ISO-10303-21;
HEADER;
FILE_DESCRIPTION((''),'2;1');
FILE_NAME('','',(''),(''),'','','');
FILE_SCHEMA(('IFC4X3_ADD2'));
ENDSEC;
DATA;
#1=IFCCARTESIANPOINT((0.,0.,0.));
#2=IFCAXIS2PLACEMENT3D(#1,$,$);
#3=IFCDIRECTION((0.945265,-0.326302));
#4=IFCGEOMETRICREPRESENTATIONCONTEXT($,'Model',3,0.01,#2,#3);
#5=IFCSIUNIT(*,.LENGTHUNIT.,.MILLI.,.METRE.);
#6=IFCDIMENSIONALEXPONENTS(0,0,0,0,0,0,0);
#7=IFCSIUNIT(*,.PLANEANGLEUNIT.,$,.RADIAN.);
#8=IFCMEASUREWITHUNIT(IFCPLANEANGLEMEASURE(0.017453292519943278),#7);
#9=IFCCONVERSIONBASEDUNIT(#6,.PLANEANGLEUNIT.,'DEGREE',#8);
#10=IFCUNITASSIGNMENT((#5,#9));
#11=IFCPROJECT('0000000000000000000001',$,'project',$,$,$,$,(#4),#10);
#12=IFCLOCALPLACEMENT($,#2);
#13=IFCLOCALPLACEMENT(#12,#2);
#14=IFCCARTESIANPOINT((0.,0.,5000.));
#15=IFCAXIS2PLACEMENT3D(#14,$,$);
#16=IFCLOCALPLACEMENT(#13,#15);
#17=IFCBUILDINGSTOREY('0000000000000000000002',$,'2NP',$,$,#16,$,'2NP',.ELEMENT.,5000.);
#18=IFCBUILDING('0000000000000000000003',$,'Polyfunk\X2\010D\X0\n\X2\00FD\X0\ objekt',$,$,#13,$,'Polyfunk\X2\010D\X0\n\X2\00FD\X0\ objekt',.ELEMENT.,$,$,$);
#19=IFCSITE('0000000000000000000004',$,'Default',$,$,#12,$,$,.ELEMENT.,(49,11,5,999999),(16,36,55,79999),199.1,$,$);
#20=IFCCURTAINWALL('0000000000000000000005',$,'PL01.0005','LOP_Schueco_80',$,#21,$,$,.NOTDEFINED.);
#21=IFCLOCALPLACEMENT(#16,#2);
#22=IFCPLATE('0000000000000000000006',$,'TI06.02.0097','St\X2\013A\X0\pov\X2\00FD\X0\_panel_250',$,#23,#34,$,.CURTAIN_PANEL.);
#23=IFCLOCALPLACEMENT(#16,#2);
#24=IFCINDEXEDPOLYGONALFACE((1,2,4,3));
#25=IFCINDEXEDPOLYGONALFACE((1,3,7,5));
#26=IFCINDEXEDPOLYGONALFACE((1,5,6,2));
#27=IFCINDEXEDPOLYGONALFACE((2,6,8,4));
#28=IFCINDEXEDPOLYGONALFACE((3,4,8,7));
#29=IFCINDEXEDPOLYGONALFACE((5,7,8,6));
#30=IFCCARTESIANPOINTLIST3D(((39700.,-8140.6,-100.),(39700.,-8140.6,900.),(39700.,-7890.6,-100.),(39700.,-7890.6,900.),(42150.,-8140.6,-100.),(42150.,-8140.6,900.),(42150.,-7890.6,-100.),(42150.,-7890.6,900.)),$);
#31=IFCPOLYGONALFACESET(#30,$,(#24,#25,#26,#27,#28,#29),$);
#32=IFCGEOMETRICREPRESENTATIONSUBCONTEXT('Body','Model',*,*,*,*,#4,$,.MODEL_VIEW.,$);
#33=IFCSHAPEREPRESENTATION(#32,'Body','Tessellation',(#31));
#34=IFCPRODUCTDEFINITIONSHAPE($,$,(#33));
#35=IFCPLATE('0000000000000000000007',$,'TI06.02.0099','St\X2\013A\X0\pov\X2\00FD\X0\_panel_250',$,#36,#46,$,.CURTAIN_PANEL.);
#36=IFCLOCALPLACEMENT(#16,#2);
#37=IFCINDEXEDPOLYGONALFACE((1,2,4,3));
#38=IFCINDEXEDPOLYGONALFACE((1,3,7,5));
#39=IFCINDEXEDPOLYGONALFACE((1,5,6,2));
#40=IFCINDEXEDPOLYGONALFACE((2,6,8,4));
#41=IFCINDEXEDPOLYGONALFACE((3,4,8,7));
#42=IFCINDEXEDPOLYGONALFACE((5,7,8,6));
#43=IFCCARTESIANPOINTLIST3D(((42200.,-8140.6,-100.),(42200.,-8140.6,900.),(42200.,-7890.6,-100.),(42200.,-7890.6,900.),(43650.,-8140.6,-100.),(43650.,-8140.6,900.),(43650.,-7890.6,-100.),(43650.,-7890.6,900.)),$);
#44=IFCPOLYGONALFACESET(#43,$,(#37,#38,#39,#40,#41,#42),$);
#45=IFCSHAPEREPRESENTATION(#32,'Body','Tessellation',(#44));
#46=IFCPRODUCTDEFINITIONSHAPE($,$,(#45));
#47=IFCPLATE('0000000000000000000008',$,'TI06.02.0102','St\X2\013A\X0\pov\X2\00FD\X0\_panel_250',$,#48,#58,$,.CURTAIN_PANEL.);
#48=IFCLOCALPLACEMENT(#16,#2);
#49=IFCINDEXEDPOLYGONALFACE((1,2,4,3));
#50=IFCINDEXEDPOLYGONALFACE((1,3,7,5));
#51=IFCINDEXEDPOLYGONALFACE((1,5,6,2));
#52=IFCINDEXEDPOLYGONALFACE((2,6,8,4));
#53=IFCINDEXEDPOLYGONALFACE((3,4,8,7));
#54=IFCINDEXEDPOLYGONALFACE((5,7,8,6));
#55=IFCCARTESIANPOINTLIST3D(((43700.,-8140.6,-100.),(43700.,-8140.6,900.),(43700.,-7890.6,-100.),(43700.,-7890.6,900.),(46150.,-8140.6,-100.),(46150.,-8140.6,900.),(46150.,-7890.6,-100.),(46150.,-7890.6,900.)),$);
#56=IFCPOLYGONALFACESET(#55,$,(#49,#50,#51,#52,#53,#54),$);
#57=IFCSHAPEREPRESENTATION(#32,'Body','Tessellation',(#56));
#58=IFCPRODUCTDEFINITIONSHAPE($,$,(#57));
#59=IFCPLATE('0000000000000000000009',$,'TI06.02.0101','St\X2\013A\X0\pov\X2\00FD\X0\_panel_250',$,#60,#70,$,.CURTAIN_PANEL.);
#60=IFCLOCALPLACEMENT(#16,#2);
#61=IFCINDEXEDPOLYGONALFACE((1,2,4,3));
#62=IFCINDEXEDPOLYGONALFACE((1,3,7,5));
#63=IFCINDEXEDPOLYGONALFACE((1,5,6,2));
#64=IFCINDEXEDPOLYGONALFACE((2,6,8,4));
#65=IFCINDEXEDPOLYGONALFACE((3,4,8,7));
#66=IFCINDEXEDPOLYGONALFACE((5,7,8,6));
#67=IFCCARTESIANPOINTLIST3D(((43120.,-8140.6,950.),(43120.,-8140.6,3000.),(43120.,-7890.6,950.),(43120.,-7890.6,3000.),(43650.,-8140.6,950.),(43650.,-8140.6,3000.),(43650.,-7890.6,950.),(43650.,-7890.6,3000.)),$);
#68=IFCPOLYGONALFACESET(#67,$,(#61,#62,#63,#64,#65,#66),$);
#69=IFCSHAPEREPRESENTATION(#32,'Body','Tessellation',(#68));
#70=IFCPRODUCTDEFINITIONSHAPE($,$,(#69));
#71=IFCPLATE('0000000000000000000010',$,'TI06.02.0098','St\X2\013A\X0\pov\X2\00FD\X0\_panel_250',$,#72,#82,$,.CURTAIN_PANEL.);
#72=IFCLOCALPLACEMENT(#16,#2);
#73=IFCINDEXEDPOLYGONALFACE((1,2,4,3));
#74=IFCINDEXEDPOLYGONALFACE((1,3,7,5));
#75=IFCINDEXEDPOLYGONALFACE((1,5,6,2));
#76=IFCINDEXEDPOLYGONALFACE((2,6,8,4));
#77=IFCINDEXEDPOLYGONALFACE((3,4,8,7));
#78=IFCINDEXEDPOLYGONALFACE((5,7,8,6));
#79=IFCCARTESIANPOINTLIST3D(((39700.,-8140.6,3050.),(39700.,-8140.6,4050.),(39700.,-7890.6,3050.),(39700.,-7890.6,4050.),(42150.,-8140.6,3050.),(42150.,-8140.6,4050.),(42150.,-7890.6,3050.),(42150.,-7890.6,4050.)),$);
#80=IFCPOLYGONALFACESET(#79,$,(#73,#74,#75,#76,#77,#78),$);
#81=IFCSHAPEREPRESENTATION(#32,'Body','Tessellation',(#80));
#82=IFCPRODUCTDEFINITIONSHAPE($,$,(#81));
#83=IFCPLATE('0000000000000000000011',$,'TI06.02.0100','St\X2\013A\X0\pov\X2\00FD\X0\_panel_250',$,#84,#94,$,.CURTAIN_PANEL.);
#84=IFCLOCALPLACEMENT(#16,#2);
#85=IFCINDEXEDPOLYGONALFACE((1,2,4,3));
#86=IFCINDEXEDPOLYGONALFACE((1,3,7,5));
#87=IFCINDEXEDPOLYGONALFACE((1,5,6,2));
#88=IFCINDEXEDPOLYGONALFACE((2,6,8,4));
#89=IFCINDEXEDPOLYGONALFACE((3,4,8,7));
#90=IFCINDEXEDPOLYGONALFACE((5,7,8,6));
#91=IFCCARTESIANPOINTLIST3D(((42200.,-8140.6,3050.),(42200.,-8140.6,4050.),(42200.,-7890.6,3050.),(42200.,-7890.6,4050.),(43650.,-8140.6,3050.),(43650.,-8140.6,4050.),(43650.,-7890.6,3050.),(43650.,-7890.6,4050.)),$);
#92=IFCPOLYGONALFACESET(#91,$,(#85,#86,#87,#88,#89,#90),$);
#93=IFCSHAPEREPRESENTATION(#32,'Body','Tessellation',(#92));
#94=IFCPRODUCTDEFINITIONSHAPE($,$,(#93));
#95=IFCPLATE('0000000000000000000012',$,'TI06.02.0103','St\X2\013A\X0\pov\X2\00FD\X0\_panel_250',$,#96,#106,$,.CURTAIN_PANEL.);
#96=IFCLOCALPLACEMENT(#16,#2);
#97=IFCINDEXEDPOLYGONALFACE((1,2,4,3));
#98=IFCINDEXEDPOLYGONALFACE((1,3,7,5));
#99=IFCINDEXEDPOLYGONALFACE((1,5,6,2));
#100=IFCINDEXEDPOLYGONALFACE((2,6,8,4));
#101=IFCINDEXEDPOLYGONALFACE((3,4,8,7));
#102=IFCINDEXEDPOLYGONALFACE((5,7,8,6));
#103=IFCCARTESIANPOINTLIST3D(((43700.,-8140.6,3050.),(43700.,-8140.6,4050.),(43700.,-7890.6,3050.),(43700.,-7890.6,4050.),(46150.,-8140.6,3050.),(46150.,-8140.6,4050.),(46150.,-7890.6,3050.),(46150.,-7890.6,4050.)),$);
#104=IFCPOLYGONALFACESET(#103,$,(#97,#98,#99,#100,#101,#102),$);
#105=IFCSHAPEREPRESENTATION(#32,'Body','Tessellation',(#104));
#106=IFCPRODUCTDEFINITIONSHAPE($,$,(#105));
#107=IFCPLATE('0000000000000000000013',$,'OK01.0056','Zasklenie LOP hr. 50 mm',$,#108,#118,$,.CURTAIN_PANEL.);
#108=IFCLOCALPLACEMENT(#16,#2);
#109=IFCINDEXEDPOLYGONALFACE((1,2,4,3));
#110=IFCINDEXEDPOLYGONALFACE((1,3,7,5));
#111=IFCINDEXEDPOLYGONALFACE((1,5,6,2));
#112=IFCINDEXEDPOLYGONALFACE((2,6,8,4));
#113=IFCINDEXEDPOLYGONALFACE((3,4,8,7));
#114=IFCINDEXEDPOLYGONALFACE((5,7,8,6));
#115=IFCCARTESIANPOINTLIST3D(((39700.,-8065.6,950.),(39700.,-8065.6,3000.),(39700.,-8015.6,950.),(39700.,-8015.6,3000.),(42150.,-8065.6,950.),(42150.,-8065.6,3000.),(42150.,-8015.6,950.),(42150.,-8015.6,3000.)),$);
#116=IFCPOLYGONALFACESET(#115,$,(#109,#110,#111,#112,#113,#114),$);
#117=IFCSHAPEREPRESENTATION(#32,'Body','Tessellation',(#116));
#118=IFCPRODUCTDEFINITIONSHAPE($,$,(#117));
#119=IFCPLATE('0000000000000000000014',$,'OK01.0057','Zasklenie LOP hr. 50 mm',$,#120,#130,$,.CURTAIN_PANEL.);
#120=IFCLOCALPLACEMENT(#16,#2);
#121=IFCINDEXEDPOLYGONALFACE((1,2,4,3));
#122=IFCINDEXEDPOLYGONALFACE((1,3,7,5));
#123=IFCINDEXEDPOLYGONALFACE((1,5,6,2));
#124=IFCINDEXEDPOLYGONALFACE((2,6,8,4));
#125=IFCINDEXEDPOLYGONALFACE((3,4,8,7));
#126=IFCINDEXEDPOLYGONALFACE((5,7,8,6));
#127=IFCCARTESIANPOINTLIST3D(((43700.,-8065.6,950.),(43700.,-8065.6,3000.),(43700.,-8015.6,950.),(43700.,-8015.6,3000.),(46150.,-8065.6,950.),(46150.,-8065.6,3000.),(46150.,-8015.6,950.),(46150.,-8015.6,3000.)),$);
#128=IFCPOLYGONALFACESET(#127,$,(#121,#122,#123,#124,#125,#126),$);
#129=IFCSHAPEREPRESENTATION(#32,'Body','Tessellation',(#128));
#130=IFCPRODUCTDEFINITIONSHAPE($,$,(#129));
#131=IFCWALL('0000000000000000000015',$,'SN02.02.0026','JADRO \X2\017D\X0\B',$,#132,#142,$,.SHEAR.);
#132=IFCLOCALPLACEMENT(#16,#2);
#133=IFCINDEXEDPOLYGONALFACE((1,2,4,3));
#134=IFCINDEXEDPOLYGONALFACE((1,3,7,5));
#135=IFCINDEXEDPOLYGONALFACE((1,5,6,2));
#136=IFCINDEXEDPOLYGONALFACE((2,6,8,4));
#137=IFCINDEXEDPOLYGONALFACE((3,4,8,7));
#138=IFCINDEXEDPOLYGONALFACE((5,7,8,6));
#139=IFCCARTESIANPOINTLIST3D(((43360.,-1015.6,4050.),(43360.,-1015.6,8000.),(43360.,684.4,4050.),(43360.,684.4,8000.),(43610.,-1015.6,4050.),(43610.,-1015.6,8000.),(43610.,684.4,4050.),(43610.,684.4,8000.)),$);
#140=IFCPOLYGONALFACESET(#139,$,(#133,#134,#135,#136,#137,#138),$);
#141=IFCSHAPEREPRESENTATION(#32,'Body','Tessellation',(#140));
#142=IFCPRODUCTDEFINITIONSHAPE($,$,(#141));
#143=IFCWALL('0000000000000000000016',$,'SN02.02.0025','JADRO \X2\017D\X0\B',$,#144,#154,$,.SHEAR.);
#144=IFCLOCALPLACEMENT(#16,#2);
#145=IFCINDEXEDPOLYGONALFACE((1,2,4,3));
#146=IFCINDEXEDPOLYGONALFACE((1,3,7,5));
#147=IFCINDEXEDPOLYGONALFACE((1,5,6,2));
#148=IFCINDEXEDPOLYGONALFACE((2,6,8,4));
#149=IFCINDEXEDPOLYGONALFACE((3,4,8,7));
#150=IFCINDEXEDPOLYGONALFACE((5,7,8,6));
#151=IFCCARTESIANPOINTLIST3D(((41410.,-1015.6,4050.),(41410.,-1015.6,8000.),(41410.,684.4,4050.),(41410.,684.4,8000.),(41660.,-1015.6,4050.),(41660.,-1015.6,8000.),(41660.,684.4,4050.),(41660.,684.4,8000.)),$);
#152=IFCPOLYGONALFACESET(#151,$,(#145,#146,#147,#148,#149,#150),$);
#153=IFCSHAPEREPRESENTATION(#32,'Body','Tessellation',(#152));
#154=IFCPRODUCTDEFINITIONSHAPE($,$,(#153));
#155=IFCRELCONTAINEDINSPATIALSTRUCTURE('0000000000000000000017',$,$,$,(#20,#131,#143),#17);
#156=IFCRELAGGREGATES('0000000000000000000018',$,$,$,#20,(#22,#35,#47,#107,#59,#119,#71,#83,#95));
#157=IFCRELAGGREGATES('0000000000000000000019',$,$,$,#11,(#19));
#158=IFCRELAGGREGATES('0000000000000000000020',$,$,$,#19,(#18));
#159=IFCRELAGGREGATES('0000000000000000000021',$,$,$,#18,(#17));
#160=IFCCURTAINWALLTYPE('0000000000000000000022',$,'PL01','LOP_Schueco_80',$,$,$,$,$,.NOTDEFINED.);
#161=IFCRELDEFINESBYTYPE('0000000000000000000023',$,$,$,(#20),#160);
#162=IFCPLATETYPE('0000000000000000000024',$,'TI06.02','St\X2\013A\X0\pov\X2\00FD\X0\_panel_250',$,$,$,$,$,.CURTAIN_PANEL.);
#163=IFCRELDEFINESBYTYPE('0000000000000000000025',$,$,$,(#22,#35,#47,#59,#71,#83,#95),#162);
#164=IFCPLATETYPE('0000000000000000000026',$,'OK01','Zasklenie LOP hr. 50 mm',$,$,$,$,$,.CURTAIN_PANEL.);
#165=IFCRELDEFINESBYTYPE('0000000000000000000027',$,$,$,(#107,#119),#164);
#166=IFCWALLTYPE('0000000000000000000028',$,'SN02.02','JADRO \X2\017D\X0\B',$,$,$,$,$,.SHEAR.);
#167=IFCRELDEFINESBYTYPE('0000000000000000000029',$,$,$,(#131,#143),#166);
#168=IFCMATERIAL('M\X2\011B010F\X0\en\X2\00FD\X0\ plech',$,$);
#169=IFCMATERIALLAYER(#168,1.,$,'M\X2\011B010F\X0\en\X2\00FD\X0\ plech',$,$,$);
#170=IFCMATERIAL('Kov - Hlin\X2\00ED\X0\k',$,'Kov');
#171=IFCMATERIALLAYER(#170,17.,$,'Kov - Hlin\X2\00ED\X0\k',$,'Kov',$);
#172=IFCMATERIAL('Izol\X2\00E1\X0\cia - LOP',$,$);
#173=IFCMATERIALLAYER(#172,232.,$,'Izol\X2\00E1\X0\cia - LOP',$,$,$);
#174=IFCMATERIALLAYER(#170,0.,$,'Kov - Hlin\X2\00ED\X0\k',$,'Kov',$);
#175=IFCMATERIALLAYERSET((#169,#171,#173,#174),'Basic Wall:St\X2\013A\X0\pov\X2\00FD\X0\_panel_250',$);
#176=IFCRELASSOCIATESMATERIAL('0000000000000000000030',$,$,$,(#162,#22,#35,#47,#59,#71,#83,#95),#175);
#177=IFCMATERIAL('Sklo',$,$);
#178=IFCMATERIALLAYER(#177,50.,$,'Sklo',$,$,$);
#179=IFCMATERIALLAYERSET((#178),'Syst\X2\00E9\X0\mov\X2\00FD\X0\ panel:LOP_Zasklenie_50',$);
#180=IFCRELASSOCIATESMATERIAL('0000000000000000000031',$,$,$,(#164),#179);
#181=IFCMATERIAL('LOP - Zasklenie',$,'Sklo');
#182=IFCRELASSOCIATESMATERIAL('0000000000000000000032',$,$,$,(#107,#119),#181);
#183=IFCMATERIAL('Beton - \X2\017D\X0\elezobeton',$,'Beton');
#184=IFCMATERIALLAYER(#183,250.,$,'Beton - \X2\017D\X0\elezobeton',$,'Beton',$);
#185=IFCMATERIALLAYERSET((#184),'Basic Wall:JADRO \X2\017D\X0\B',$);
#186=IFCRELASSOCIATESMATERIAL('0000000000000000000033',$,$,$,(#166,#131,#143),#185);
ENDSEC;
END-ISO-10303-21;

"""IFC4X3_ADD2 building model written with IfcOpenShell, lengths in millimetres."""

from ifc_helpers import new_model, entity, si_unit, converted_unit, direction, frame, frame_2d, origin, origin_2d_with_axis, place, context, subcontext, project, spatial, polyline, rectangle, extrude, clip, bounded_halfspace, source, transform, mapped, material, layer, layer_set, layer_usage, type_object, type_shapes, element, aggregate, save


model = new_model("IFC4X3_ADD2")

# Units and contexts
model_context = context("Model", 3, precision=0.01, world=origin(), true_north=direction((0.945265, -0.326302)))
body_context = subcontext(model_context, "Body", "Model", "MODEL_VIEW")
ifc_project = project(units=[si_unit("LENGTHUNIT", "METRE", prefix="MILLI"), converted_unit("PLANEANGLEUNIT", "DEGREE", entity("IfcPlaneAngleMeasure", 0.017453292519943278), si_unit("PLANEANGLEUNIT", "RADIAN"), dimensions=[0, 0, 0, 0, 0, 0, 0])], contexts=[model_context])

# Site, building, storey
site_placement = place(None, origin())
site = spatial("IfcSite", under=ifc_project, at=site_placement, Name="Default", CompositionType="ELEMENT", RefLatitude=(49, 11, 5, 999999), RefLongitude=(16, 36, 55, 79999), RefElevation=199.1)
building_placement = place(site_placement, origin())
building = spatial("IfcBuilding", under=site, at=building_placement, Name="Polyfunkčný objekt", LongName="Polyfunkčný objekt", CompositionType="ELEMENT")
storey_placement = place(building_placement, frame((0.0, 0.0, 5000.0)))
storey = spatial("IfcBuildingStorey", under=building, at=storey_placement, Name="2NP", LongName="2NP", CompositionType="ELEMENT", Elevation=5000.0)

# Curtain wall, plates
curtain_wall_type = type_object("IfcCurtainWallType", Name="PL01", Description="LOP_Schueco_80", PredefinedType="NOTDEFINED")
curtain_wall_placement = place(storey_placement, frame((0.0, 0.0, -5000.0)))
curtain_wall = element("IfcCurtainWall", 1, at=curtain_wall_placement, inside=storey, type_object=curtain_wall_type, Name="PL01.0005", Description="LOP_Schueco_80", PredefinedType="NOTDEFINED")
ifc_material_1 = material(Name="Měďený plech")
ifc_layer_1 = layer(ifc_material_1, 1.0, Name="Měďený plech")
ifc_material_2 = material(Name="Kov - Hliník", Category="Kov")
ifc_layer_2 = layer(ifc_material_2, 17.0, Name="Kov - Hliník", Category="Kov")
ifc_material_3 = material(Name="Izolácia - LOP")
ifc_layer_3 = layer(ifc_material_3, 232.0, Name="Izolácia - LOP")
ifc_layer_4 = layer(ifc_material_2, 0.0, Name="Kov - Hliník", Category="Kov")
ifc_layer_set_1 = layer_set([ifc_layer_1, ifc_layer_2, ifc_layer_3, ifc_layer_4], Name="Basic Wall:Stĺpový_panel_250")
ifc_layer_usage_1 = layer_usage(ifc_layer_set_1, "AXIS2", "POSITIVE", -125.0)
plate_type_1 = type_object("IfcPlateType", Name="TI06.02", Description="Stĺpový_panel_250", PredefinedType="CURTAIN_PANEL", material=ifc_layer_set_1)
plate_1_placement = place(storey_placement, frame((39700.0, -8015.6, -100.0)))
plate_1 = element("IfcPlate", 2, at=plate_1_placement, type_object=plate_type_1, material=ifc_layer_usage_1, Name="TI06.02.0097", Description="Stĺpový_panel_250", PredefinedType="CURTAIN_PANEL", context=body_context, shape_type="SweptSolid", body=[
    extrude(rectangle(XDim=250.0, YDim=2450.0, at=frame_2d((0.0, 0.0), x_axis=(1.0, 0.0))), frame((1225.0, 0.0, 0.0), z_axis=(0.0, 0.0, 1.0), x_axis=(0.0, 1.0, 0.0)), (0.0, 0.0, 1.0), 1000.0),
])
ifc_layer_usage_2 = layer_usage(ifc_layer_set_1, "AXIS2", "POSITIVE", -125.0)
plate_2_placement = place(storey_placement, frame((42200.0, -8015.6, -100.0)))
plate_2 = element("IfcPlate", 3, at=plate_2_placement, type_object=plate_type_1, material=ifc_layer_usage_2, Name="TI06.02.0099", Description="Stĺpový_panel_250", PredefinedType="CURTAIN_PANEL", context=body_context, shape_type="SweptSolid", body=[
    extrude(rectangle(XDim=250.0, YDim=1450.0, at=frame_2d((0.0, 0.0), x_axis=(1.0, 0.0))), frame((725.0, 0.0, 0.0), z_axis=(0.0, 0.0, 1.0), x_axis=(0.0, 1.0, 0.0)), (0.0, 0.0, 1.0), 1000.0),
])
ifc_layer_usage_3 = layer_usage(ifc_layer_set_1, "AXIS2", "POSITIVE", -125.0)
plate_3_placement = place(storey_placement, frame((43700.0, -8015.6, -100.0)))
plate_3 = element("IfcPlate", 4, at=plate_3_placement, type_object=plate_type_1, material=ifc_layer_usage_3, Name="TI06.02.0102", Description="Stĺpový_panel_250", PredefinedType="CURTAIN_PANEL", context=body_context, shape_type="SweptSolid", body=[
    extrude(rectangle(XDim=250.0, YDim=2450.0, at=frame_2d((0.0, 0.0), x_axis=(1.0, 0.0))), frame((1225.0, 0.0, 0.0), z_axis=(0.0, 0.0, 1.0), x_axis=(0.0, 1.0, 0.0)), (0.0, 0.0, 1.0), 1000.0),
])
ifc_layer_usage_4 = layer_usage(ifc_layer_set_1, "AXIS2", "POSITIVE", -125.0)
plate_4_placement = place(storey_placement, frame((43120.0, -8015.6, 950.0)))
plate_4 = element("IfcPlate", 5, at=plate_4_placement, type_object=plate_type_1, material=ifc_layer_usage_4, Name="TI06.02.0101", Description="Stĺpový_panel_250", PredefinedType="CURTAIN_PANEL", context=body_context, shape_type="SweptSolid", body=[
    extrude(rectangle(XDim=250.0, YDim=530.0, at=frame_2d((0.0, 0.0), x_axis=(1.0, 0.0))), frame((265.0, 0.0, 0.0), z_axis=(0.0, 0.0, 1.0), x_axis=(0.0, 1.0, 0.0)), (0.0, 0.0, 1.0), 2050.0),
])
ifc_layer_usage_5 = layer_usage(ifc_layer_set_1, "AXIS2", "POSITIVE", -125.0)
plate_5_placement = place(storey_placement, frame((39700.0, -8015.6, 3050.0)))
plate_5 = element("IfcPlate", 6, at=plate_5_placement, type_object=plate_type_1, material=ifc_layer_usage_5, Name="TI06.02.0098", Description="Stĺpový_panel_250", PredefinedType="CURTAIN_PANEL", context=body_context, shape_type="SweptSolid", body=[
    extrude(rectangle(XDim=250.0, YDim=2450.0, at=frame_2d((0.0, 0.0), x_axis=(1.0, 0.0))), frame((1225.0, 0.0, 0.0), z_axis=(0.0, 0.0, 1.0), x_axis=(0.0, 1.0, 0.0)), (0.0, 0.0, 1.0), 1000.0),
])
ifc_layer_usage_6 = layer_usage(ifc_layer_set_1, "AXIS2", "POSITIVE", -125.0)
plate_6_placement = place(storey_placement, frame((42200.0, -8015.6, 3050.0)))
plate_6 = element("IfcPlate", 7, at=plate_6_placement, type_object=plate_type_1, material=ifc_layer_usage_6, Name="TI06.02.0100", Description="Stĺpový_panel_250", PredefinedType="CURTAIN_PANEL", context=body_context, shape_type="SweptSolid", body=[
    extrude(rectangle(XDim=250.0, YDim=1450.0, at=frame_2d((0.0, 0.0), x_axis=(1.0, 0.0))), frame((725.0, 0.0, 0.0), z_axis=(0.0, 0.0, 1.0), x_axis=(0.0, 1.0, 0.0)), (0.0, 0.0, 1.0), 1000.0),
])
ifc_layer_usage_7 = layer_usage(ifc_layer_set_1, "AXIS2", "POSITIVE", -125.0)
plate_7_placement = place(storey_placement, frame((43700.0, -8015.6, 3050.0)))
plate_7 = element("IfcPlate", 8, at=plate_7_placement, type_object=plate_type_1, material=ifc_layer_usage_7, Name="TI06.02.0103", Description="Stĺpový_panel_250", PredefinedType="CURTAIN_PANEL", context=body_context, shape_type="SweptSolid", body=[
    extrude(rectangle(XDim=250.0, YDim=2450.0, at=frame_2d((0.0, 0.0), x_axis=(1.0, 0.0))), frame((1225.0, 0.0, 0.0), z_axis=(0.0, 0.0, 1.0), x_axis=(0.0, 1.0, 0.0)), (0.0, 0.0, 1.0), 1000.0),
])
ifc_material_4 = material(Name="LOP - Zasklenie", Category="Sklo")
ifc_material_5 = material(Name="Sklo")
ifc_layer_5 = layer(ifc_material_5, 50.0, Name="Sklo")
ifc_layer_set_2 = layer_set([ifc_layer_5], Name="Systémový panel:LOP_Zasklenie_50")
plate_type_2 = type_object("IfcPlateType", Name="OK01", Description="Zasklenie LOP hr. 50 mm", PredefinedType="CURTAIN_PANEL", material=ifc_layer_set_2)
shared_shape_1 = source(origin(), body_context, "Body", "SweptSolid", [
    extrude(rectangle(XDim=50.0, YDim=2450.0, at=origin_2d_with_axis()), frame((0.0, -25.0, 0.0), z_axis=(0.0, 0.0, 1.0), x_axis=(0.0, 1.0, 0.0)), (0.0, 0.0, 1.0), 2050.0),
])
type_shapes(plate_type_2, [shared_shape_1])
plate_8_placement = place(curtain_wall_placement, frame((40925.0, -8015.6, 5950.0)))
plate_8 = element("IfcPlate", 9, at=plate_8_placement, type_object=plate_type_2, material=ifc_material_4, Name="OK01.0056", Description="Zasklenie LOP hr. 50 mm", PredefinedType="CURTAIN_PANEL", context=body_context, shape_type="MappedRepresentation", body=[
    mapped(shared_shape_1, transform((0.0, 0.0, 0.0), scale=1.0)),
])
plate_9_placement = place(curtain_wall_placement, frame((44925.0, -8015.6, 5950.0)))
plate_9 = element("IfcPlate", 10, at=plate_9_placement, type_object=plate_type_2, material=ifc_material_4, Name="OK01.0057", Description="Zasklenie LOP hr. 50 mm", PredefinedType="CURTAIN_PANEL", context=body_context, shape_type="MappedRepresentation", body=[
    mapped(shared_shape_1, transform((0.0, 0.0, 0.0), scale=1.0)),
])

# Walls
ifc_material_6 = material(Name="Beton - Železobeton", Category="Beton")
ifc_layer_6 = layer(ifc_material_6, 250.0, Name="Beton - Železobeton", Category="Beton")
ifc_layer_set_3 = layer_set([ifc_layer_6], Name="Basic Wall:JADRO ŽB")
wall_type = type_object("IfcWallType", Name="SN02.02", Description="JADRO ŽB", PredefinedType="SHEAR", material=ifc_layer_set_3)
wall_1_placement = place(storey_placement, frame((43485.0, 684.4, 4050.0), z_axis=(0.0, 0.0, 1.0), x_axis=(0.0, -1.0, 0.0)))
element("IfcWall", 11, at=wall_1_placement, inside=storey, type_object=wall_type, material=ifc_layer_set_3, Name="SN02.02.0026", Description="JADRO ŽB", PredefinedType="SHEAR", context=body_context, shape_type="Clipping", body=[
    clip(clip(extrude(rectangle(XDim=1700.0, YDim=250.0, at=frame_2d((850.0, 0.0), x_axis=(-1.0, 0.0))), origin(), (0.0, 0.0, 1.0), 3950.0), bounded_halfspace(frame((1700.0, -125.0, 0.0), z_axis=(0.0, 0.0, 1.0), x_axis=(0.0, -1.0, 0.0)), True, frame((1700.0, -125.0, 0.0)), polyline([(0.0, 0.0), (0.0, 250.0), (-1700.0, 250.0), (-1700.0, 0.0), (0.0, 0.0)]))), bounded_halfspace(frame((0.0, -125.0, 3950.0), z_axis=(0.0, 0.0, -1.0), x_axis=(0.0, 1.0, 0.0)), True, frame((0.0, -125.0, 3950.0)), polyline([(0.0, 0.0), (1700.0, 0.0), (1700.0, 250.0), (0.0, 250.0), (0.0, 0.0)]))),
])
wall_2_placement = place(storey_placement, frame((41535.0, 684.4, 4050.0), z_axis=(0.0, 0.0, 1.0), x_axis=(0.0, -1.0, 0.0)))
element("IfcWall", 12, at=wall_2_placement, inside=storey, type_object=wall_type, material=ifc_layer_set_3, Name="SN02.02.0025", Description="JADRO ŽB", PredefinedType="SHEAR", context=body_context, shape_type="Clipping", body=[
    clip(clip(extrude(rectangle(XDim=1700.0, YDim=250.0, at=frame_2d((850.0, 0.0), x_axis=(-1.0, 0.0))), origin(), (0.0, 0.0, 1.0), 3950.0), bounded_halfspace(frame((1700.0, -125.0, 0.0), z_axis=(0.0, 0.0, 1.0), x_axis=(0.0, -1.0, 0.0)), True, frame((1700.0, -125.0, 0.0)), polyline([(0.0, 0.0), (0.0, 250.0), (-1700.0, 250.0), (-1700.0, 0.0), (0.0, 0.0)]))), bounded_halfspace(frame((0.0, -125.0, 3950.0), z_axis=(0.0, 0.0, -1.0), x_axis=(0.0, 1.0, 0.0)), True, frame((0.0, -125.0, 3950.0)), polyline([(0.0, 0.0), (1700.0, 0.0), (1700.0, 250.0), (0.0, 250.0), (0.0, 0.0)]))),
])

aggregate(curtain_wall, [plate_1, plate_2, plate_3, plate_8, plate_4, plate_9, plate_5, plate_6, plate_7])

save(model, "model.ifc")
